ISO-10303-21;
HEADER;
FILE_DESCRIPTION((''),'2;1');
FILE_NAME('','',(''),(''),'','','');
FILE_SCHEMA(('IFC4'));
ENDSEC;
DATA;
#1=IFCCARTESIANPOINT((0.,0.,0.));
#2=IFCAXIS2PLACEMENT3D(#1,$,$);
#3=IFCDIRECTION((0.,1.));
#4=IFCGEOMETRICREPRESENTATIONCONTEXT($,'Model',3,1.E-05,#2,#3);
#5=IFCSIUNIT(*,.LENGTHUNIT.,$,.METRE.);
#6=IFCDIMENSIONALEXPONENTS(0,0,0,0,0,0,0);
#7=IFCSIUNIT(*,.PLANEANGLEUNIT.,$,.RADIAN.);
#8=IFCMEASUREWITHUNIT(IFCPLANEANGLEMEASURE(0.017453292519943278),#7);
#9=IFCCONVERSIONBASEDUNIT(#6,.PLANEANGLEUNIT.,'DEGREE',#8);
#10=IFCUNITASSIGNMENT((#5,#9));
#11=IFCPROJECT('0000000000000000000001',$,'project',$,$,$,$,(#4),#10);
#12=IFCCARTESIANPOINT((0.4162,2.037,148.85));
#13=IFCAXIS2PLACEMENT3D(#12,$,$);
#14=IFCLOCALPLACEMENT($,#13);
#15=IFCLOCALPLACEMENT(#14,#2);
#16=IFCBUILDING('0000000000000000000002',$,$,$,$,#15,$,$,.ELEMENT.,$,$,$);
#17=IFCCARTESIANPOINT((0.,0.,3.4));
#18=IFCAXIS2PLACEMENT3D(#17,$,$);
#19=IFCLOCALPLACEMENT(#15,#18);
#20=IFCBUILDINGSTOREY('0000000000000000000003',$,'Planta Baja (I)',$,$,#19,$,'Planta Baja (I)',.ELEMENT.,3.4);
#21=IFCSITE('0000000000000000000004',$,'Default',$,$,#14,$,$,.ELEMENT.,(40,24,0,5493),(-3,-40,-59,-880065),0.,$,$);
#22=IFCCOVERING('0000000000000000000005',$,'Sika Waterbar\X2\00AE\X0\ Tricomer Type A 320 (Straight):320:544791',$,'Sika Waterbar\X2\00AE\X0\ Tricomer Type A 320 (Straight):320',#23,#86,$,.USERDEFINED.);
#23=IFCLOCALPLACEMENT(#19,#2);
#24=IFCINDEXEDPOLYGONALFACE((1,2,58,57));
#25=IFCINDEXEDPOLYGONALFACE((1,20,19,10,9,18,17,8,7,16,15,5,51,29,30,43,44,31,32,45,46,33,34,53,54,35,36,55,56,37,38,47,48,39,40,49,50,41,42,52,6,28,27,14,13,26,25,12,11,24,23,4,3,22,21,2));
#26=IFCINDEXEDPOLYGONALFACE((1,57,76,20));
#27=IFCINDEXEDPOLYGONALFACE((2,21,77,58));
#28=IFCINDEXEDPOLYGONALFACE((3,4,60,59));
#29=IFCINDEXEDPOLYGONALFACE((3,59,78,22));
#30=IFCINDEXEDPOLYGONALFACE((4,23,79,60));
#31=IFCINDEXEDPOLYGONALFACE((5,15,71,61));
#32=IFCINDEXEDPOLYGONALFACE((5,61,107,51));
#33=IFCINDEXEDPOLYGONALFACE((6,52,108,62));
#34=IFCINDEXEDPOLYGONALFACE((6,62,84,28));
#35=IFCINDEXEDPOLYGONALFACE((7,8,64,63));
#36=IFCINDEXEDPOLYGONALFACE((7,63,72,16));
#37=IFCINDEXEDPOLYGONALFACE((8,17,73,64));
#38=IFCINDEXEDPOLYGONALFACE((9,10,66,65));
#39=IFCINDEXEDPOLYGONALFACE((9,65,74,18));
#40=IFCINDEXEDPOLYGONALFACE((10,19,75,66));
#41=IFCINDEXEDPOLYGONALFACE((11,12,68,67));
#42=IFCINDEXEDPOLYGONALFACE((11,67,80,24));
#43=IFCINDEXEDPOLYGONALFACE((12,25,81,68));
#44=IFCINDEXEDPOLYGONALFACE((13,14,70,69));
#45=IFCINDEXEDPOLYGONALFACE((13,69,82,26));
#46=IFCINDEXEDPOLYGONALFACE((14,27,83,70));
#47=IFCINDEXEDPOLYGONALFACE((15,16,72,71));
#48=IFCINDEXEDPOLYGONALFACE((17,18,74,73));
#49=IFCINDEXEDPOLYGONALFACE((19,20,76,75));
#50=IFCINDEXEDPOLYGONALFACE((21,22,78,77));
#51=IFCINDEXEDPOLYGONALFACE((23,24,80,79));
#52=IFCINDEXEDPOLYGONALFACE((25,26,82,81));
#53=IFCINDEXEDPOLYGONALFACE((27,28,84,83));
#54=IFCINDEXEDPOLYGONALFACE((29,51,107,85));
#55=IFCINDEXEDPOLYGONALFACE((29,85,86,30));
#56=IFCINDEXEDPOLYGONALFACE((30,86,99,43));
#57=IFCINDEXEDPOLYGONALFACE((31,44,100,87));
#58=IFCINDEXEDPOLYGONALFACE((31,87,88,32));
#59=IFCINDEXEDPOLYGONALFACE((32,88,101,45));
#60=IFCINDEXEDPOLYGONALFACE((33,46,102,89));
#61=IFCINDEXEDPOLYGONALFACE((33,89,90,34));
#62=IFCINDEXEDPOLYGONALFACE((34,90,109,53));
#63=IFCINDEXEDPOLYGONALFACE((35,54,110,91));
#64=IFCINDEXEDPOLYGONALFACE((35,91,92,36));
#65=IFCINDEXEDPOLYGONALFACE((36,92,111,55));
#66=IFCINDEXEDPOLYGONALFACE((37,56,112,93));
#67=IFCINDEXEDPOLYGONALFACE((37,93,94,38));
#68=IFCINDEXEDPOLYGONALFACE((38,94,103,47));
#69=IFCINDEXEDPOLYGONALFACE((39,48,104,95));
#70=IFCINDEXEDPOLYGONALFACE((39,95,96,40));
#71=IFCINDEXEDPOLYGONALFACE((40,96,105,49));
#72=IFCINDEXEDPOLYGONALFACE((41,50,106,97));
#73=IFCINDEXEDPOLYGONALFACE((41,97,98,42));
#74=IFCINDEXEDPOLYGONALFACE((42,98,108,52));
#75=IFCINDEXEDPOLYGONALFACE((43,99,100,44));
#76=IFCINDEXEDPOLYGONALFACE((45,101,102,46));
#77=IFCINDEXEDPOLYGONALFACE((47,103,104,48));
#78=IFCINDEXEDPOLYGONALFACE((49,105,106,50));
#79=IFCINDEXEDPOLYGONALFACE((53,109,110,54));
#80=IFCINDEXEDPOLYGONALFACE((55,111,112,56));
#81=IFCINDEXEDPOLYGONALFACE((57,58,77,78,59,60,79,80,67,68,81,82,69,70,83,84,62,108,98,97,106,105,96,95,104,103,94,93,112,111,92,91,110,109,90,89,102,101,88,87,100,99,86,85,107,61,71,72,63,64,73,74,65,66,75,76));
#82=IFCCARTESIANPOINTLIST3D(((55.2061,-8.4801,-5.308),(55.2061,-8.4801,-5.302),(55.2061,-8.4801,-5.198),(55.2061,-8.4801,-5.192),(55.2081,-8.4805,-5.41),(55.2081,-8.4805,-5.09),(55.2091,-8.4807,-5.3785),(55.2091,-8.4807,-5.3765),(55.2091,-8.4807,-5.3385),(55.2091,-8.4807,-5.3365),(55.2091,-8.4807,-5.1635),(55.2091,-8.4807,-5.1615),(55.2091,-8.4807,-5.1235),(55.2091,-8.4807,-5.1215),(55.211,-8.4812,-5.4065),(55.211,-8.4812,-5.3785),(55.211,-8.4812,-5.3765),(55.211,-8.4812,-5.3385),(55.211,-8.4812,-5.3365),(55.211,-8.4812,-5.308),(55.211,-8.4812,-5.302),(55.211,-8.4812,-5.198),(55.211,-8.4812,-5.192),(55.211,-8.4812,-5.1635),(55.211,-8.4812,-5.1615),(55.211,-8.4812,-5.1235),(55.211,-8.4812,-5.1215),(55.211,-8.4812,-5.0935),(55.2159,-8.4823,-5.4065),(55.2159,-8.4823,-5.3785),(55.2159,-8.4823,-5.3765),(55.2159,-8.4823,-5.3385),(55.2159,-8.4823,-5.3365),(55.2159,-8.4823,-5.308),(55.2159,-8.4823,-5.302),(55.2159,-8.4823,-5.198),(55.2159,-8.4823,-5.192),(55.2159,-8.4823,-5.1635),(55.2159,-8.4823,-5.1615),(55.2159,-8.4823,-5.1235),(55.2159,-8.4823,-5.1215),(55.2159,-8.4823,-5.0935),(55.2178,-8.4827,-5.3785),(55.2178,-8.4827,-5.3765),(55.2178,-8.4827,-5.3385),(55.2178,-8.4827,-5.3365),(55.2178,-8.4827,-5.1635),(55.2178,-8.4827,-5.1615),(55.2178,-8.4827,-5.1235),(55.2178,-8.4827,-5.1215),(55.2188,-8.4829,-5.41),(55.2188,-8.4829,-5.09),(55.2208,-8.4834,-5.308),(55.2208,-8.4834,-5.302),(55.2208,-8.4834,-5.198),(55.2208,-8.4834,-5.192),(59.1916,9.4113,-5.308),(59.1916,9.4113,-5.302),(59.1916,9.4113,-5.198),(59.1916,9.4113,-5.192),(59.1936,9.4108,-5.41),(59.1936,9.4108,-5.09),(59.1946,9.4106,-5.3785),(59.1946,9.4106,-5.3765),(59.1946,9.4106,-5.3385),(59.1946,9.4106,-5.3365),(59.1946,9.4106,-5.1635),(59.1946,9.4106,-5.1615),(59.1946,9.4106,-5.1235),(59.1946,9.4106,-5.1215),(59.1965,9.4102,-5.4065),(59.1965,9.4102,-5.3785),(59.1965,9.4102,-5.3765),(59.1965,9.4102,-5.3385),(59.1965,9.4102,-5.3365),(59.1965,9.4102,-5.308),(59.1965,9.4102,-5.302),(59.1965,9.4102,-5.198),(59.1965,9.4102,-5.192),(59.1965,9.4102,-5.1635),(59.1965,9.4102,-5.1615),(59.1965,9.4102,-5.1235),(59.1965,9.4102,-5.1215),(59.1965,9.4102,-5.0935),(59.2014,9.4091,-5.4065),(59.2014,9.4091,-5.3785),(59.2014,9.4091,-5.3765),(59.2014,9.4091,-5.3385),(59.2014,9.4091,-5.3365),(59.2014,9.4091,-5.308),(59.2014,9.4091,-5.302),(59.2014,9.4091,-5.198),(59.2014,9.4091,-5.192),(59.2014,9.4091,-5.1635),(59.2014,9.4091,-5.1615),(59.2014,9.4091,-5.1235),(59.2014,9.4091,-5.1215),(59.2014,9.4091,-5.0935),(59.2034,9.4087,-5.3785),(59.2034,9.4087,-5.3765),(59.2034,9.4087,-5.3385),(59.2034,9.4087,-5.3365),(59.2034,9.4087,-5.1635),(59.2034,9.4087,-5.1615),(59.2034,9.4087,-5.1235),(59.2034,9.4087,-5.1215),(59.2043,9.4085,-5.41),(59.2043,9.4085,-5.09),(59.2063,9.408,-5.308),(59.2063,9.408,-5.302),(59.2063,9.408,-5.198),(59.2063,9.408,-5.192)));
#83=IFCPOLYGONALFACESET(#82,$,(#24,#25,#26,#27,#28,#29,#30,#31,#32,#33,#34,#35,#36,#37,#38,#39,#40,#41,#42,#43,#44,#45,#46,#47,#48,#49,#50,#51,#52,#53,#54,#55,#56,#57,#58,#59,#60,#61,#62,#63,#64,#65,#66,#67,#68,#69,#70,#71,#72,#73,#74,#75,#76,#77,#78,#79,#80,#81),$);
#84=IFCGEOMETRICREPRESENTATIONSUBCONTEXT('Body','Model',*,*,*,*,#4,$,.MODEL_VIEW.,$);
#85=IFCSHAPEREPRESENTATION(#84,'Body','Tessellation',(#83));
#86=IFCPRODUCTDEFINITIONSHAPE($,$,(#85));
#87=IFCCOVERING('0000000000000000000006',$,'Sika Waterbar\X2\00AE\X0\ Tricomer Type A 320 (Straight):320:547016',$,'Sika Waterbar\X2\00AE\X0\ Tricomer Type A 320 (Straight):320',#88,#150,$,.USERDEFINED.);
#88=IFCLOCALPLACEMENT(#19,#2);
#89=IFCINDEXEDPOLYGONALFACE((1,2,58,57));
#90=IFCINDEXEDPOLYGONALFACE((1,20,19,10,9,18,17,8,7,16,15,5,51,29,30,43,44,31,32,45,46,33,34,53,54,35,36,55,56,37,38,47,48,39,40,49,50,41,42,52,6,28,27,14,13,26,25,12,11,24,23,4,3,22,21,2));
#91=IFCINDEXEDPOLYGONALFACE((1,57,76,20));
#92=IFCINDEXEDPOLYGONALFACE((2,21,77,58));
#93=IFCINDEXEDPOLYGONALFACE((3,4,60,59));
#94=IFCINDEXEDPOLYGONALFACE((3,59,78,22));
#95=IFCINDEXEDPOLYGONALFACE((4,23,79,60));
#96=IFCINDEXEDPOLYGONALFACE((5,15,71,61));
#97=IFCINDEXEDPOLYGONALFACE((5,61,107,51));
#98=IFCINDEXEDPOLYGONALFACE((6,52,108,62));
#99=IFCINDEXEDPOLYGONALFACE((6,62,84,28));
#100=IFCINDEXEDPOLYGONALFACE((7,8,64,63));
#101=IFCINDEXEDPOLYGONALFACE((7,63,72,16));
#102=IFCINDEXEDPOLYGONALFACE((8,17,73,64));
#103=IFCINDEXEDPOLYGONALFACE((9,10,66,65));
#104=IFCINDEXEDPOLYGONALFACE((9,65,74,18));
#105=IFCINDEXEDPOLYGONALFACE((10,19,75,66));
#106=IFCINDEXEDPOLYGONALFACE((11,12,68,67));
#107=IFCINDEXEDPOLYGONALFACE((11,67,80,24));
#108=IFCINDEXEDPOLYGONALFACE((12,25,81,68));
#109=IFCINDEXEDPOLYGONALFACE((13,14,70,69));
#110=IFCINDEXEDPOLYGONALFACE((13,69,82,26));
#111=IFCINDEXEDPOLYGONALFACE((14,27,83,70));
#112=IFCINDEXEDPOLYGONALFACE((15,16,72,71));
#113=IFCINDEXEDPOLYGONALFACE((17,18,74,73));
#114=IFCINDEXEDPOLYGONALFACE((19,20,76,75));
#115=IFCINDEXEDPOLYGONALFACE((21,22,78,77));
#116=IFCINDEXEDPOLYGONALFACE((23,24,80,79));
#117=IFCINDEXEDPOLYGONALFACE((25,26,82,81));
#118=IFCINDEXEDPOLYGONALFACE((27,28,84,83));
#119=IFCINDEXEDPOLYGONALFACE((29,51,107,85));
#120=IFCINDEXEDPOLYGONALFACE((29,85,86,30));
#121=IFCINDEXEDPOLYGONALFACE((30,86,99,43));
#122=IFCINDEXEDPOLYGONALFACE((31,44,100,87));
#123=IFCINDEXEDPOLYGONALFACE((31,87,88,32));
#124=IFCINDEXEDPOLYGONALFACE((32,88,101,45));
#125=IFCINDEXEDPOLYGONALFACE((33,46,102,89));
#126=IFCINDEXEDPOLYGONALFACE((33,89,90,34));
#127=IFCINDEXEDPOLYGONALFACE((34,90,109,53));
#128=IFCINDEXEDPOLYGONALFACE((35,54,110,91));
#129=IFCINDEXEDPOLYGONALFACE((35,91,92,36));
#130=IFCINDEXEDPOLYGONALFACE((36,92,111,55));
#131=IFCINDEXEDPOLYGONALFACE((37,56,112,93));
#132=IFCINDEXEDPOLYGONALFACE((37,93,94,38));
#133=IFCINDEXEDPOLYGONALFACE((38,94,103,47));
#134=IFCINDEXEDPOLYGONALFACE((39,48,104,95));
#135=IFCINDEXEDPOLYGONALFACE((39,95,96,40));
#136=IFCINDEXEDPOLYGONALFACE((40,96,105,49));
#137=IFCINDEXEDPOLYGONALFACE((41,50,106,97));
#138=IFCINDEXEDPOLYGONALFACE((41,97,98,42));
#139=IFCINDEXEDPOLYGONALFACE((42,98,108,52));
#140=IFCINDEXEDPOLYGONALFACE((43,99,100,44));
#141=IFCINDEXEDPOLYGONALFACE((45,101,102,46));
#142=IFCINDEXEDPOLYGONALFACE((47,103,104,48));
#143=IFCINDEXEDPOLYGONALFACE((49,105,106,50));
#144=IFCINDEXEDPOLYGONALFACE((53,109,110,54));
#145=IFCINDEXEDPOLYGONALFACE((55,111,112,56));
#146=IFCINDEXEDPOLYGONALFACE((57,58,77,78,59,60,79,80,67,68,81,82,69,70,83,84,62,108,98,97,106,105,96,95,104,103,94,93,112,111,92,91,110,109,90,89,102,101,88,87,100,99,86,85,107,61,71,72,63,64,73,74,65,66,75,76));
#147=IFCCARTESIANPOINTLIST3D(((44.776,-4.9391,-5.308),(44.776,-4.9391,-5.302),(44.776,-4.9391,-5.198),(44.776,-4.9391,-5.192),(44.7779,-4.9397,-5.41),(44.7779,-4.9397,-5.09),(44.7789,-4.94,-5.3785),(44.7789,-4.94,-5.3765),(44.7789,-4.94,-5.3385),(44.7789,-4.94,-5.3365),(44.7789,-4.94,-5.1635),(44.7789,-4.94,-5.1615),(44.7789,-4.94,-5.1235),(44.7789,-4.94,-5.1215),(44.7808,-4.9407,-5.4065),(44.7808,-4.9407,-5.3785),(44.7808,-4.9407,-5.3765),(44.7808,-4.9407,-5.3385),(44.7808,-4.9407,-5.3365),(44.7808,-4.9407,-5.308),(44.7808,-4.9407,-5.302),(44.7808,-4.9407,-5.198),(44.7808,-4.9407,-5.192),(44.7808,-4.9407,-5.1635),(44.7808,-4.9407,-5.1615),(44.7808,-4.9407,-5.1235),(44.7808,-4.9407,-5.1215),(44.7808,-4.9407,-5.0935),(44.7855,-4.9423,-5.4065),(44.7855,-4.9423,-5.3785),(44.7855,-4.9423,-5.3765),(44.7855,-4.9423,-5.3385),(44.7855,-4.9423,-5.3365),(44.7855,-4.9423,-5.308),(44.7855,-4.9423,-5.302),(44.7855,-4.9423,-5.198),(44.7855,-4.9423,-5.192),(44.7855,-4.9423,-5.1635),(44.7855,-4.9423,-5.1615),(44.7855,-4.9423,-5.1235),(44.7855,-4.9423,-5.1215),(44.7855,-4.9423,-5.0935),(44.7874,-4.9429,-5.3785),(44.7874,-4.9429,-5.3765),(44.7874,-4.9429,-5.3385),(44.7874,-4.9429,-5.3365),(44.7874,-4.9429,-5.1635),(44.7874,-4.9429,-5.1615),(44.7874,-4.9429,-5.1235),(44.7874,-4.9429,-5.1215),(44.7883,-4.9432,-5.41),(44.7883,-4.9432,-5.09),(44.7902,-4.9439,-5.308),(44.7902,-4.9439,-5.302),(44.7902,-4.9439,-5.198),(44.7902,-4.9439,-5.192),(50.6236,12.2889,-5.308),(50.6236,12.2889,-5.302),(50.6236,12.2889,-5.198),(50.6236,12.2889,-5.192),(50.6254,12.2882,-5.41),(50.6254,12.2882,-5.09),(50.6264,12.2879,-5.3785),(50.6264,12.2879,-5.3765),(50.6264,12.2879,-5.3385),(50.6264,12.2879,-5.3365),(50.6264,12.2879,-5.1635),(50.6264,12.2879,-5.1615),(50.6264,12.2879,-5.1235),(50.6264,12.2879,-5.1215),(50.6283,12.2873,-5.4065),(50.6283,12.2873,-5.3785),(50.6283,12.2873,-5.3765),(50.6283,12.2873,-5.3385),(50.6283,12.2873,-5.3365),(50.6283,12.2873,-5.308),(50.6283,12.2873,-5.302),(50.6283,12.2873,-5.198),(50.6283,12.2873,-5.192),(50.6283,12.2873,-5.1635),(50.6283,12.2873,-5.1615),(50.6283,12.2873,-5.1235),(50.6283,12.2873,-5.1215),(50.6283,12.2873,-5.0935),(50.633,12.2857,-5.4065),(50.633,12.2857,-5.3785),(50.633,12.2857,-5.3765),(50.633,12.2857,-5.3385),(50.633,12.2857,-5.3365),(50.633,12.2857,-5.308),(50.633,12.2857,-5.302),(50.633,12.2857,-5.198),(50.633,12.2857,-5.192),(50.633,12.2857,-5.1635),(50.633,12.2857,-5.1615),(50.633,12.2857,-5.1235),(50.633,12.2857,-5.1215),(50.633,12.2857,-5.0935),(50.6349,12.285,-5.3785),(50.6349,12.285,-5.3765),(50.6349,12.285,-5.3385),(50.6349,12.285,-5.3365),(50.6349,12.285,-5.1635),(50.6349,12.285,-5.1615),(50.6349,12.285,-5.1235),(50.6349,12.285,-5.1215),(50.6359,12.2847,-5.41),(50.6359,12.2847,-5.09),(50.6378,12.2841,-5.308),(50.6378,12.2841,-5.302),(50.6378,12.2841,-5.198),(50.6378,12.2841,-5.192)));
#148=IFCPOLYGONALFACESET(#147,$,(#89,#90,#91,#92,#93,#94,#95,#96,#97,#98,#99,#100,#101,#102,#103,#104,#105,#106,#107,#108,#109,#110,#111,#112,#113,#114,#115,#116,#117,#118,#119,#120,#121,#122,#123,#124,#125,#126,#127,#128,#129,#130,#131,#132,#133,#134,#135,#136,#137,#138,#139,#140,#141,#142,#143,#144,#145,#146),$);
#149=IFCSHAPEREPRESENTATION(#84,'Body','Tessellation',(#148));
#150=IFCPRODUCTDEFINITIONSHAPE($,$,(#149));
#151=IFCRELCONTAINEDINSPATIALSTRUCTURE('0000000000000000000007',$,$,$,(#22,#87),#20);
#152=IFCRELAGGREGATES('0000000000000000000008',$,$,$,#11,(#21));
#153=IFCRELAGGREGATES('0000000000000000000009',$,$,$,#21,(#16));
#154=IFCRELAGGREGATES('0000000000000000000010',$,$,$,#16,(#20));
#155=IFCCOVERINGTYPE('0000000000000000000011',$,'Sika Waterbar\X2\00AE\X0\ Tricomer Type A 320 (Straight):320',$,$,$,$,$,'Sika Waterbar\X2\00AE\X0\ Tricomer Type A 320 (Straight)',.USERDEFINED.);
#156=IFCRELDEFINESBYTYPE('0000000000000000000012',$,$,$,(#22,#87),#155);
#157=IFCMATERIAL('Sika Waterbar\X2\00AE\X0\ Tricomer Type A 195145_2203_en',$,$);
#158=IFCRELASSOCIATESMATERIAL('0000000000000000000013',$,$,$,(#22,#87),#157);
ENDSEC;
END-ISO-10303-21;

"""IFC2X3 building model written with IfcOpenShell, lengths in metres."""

from ifc_helpers import new_model, entity, si_unit, converted_unit, direction, frame, origin, place, context, subcontext, project, spatial, polyline, outline, extrude, material, type_object, element, save


model = new_model("IFC2X3")

# Units and contexts
model_context = context("Model", 3, precision=1e-05, world=origin(), true_north=direction((0.0, 1.0)))
body_context = subcontext(model_context, "Body", "Model", "MODEL_VIEW")
ifc_project = project(units=[si_unit("LENGTHUNIT", "METRE"), converted_unit("PLANEANGLEUNIT", "DEGREE", entity("IfcPlaneAngleMeasure", 0.017453292519943278), si_unit("PLANEANGLEUNIT", "RADIAN"), dimensions=[0, 0, 0, 0, 0, 0, 0])], contexts=[model_context])

# Site, building, storey
site_placement = place(None, frame((0.4162, 2.037, 148.85)))
site = spatial("IfcSite", under=ifc_project, at=site_placement, Name="Default", CompositionType="ELEMENT", RefLatitude=(40, 24, 0, 5493), RefLongitude=(-3, -40, -59, -880065), RefElevation=0.0)
building_placement = place(site_placement, origin())
building = spatial("IfcBuilding", under=site, at=building_placement, CompositionType="ELEMENT")
storey_placement = place(building_placement, frame((0.0, 0.0, 3.4)))
storey = spatial("IfcBuildingStorey", under=building, at=storey_placement, Name="Planta Baja (I)", LongName="Planta Baja (I)", CompositionType="ELEMENT", Elevation=3.4)

# Coverings
ifc_material_1 = material(Name="Sika Waterbar® Tricomer Type A 195145_2203_en")
covering_type = type_object("IfcCoveringType", Name="Sika Waterbar® Tricomer Type A 320 (Straight):320", ElementType="Sika Waterbar® Tricomer Type A 320 (Straight)", PredefinedType="USERDEFINED")
covering_1_placement = place(storey_placement, origin())
element("IfcCovering", 1, at=covering_1_placement, inside=storey, type_object=covering_type, material=ifc_material_1, Name="Sika Waterbar® Tricomer Type A 320 (Straight):320:544791", ObjectType="Sika Waterbar® Tricomer Type A 320 (Straight):320", PredefinedType="USERDEFINED", context=body_context, shape_type="SweptSolid", body=[
    extrude(outline(polyline([(-0.0075, -0.052), (-0.0075, -0.058), (-0.0025, -0.058), (-0.0025, -0.0865), (-0.0045, -0.0865), (-0.0045, -0.0885), (-0.0025, -0.0885), (-0.0025, -0.1265), (-0.0045, -0.1265), (-0.0045, -0.1285), (-0.0025, -0.1285), (-0.0025, -0.1565), (-0.0055, -0.16), (0.0055, -0.16), (0.0025, -0.1565), (0.0025, -0.1285), (0.0045, -0.1285), (0.0045, -0.1265), (0.0025, -0.1265), (0.0025, -0.0885), (0.0045, -0.0885), (0.0045, -0.0865), (0.0025, -0.0865), (0.0025, -0.058), (0.0075, -0.058), (0.0075, -0.052), (0.0025, -0.052), (0.0025, 0.052), (0.0075, 0.052), (0.0075, 0.058), (0.0025, 0.058), (0.0025, 0.0865), (0.0045, 0.0865), (0.0045, 0.0885), (0.0025, 0.0885), (0.0025, 0.1265), (0.0045, 0.1265), (0.0045, 0.1285), (0.0025, 0.1285), (0.0025, 0.1565), (0.0055, 0.16), (-0.0055, 0.16), (-0.0025, 0.1565), (-0.0025, 0.1285), (-0.0045, 0.1285), (-0.0045, 0.1265), (-0.0025, 0.1265), (-0.0025, 0.0885), (-0.0045, 0.0885), (-0.0045, 0.0865), (-0.0025, 0.0865), (-0.0025, 0.058), (-0.0075, 0.058), (-0.0075, 0.052), (-0.0025, 0.052), (-0.0025, -0.052), (-0.0075, -0.052)])), frame((55.2134, -8.4817, -5.25), z_axis=(-0.217433, -0.976075, 0.0), x_axis=(0.976075, -0.217433, 0.0)), (0.0, 0.0, -1.0), 18.3299),
])
covering_2_placement = place(storey_placement, origin())
element("IfcCovering", 2, at=covering_2_placement, inside=storey, type_object=covering_type, material=ifc_material_1, Name="Sika Waterbar® Tricomer Type A 320 (Straight):320:547016", ObjectType="Sika Waterbar® Tricomer Type A 320 (Straight):320", PredefinedType="USERDEFINED", context=body_context, shape_type="SweptSolid", body=[
    extrude(outline(polyline([(0.052, -0.0075), (0.058, -0.0075), (0.058, -0.0025), (0.0865, -0.0025), (0.0865, -0.0045), (0.0885, -0.0045), (0.0885, -0.0025), (0.1265, -0.0025), (0.1265, -0.0045), (0.1285, -0.0045), (0.1285, -0.0025), (0.1565, -0.0025), (0.16, -0.0055), (0.16, 0.0055), (0.1565, 0.0025), (0.1285, 0.0025), (0.1285, 0.0045), (0.1265, 0.0045), (0.1265, 0.0025), (0.0885, 0.0025), (0.0885, 0.0045), (0.0865, 0.0045), (0.0865, 0.0025), (0.058, 0.0025), (0.058, 0.0075), (0.052, 0.0075), (0.052, 0.0025), (-0.052, 0.0025), (-0.052, 0.0075), (-0.058, 0.0075), (-0.058, 0.0025), (-0.0865, 0.0025), (-0.0865, 0.0045), (-0.0885, 0.0045), (-0.0885, 0.0025), (-0.1265, 0.0025), (-0.1265, 0.0045), (-0.1285, 0.0045), (-0.1285, 0.0025), (-0.1565, 0.0025), (-0.16, 0.0055), (-0.16, -0.0055), (-0.1565, -0.0025), (-0.1285, -0.0025), (-0.1285, -0.0045), (-0.1265, -0.0045), (-0.1265, -0.0025), (-0.0885, -0.0025), (-0.0885, -0.0045), (-0.0865, -0.0045), (-0.0865, -0.0025), (-0.058, -0.0025), (-0.058, -0.0075), (-0.052, -0.0075), (-0.052, -0.0025), (0.052, -0.0025), (0.052, -0.0075)])), frame((44.7831, -4.9415, -5.25), z_axis=(0.321411, 0.94694, 0.0), x_axis=(0.0, 0.0, -1.0)), (0.0, 0.0, 1.0), 18.1933),
])

save(model, "model.ifc")
